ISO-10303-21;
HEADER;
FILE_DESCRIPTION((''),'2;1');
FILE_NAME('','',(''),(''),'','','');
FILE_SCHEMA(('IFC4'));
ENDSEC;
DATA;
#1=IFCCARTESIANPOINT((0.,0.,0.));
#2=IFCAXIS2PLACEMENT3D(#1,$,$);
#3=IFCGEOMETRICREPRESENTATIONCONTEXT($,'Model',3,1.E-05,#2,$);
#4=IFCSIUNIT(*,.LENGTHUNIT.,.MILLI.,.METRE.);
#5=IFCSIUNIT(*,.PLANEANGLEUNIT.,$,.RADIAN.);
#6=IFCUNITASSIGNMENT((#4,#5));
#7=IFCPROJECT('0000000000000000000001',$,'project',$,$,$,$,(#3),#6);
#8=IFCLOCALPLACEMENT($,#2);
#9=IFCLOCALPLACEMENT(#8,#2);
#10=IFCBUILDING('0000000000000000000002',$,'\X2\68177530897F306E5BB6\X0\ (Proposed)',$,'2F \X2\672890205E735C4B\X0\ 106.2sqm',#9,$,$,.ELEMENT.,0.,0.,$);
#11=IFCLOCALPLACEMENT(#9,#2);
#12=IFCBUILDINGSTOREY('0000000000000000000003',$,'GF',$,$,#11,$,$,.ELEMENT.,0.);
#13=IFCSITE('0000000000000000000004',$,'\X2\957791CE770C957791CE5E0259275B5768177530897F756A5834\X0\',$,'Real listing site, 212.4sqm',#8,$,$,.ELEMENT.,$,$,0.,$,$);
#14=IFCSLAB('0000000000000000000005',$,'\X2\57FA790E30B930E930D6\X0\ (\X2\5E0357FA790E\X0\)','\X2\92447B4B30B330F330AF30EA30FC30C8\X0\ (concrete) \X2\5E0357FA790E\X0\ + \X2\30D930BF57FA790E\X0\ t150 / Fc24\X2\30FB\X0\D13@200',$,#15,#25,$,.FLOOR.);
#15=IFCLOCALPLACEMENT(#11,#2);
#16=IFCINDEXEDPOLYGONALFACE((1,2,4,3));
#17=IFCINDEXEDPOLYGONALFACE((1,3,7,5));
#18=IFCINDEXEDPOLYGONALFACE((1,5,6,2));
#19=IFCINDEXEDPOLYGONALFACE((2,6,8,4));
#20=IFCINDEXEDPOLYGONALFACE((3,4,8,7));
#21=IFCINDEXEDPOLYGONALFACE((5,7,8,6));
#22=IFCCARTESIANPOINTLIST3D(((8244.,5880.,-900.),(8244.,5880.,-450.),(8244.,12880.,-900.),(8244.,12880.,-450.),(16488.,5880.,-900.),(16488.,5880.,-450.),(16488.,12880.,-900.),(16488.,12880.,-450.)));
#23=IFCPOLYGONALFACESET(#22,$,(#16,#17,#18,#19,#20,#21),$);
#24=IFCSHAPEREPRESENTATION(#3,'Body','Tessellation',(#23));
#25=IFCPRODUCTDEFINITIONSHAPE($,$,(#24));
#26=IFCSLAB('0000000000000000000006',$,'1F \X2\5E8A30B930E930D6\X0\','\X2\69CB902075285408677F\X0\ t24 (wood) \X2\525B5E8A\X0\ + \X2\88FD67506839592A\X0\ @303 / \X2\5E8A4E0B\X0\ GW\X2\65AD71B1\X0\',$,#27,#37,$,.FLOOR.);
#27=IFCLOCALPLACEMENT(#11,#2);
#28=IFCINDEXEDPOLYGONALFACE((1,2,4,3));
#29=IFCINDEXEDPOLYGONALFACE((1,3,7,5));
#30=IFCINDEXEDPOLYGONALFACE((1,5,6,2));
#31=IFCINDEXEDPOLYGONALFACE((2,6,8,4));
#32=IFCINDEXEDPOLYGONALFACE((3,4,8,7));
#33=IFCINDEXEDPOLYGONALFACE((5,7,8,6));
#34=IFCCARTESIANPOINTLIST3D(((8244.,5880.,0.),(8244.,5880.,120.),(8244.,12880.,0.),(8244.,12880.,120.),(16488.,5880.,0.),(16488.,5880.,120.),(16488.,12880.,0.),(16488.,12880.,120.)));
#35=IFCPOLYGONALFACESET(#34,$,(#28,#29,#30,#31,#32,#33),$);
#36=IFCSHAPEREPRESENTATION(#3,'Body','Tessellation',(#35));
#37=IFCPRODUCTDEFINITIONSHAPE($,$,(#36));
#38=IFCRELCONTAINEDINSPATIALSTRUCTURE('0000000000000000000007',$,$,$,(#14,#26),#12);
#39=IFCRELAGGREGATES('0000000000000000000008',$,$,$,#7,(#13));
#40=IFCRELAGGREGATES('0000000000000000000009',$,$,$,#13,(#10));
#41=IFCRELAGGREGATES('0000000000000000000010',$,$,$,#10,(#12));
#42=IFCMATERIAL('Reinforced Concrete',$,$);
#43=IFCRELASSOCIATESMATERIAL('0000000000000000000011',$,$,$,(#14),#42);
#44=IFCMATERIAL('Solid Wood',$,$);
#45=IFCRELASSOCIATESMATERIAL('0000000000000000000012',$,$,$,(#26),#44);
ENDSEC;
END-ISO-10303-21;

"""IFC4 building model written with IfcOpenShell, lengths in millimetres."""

from ifc_helpers import new_model, si_unit, frame, frame_2d, origin, place, context, project, spatial, rectangle, extrude, material, element, save


model = new_model("IFC4")

# Units and contexts
model_context = context("Model", 3, precision=1e-05, world=origin())
ifc_project = project(units=[si_unit("LENGTHUNIT", "METRE", prefix="MILLI"), si_unit("PLANEANGLEUNIT", "RADIAN")], contexts=[model_context])

# Site, building, storey
site_placement = place(None, origin())
site = spatial("IfcSite", under=ifc_project, at=site_placement, Name="長野県長野市大字栗田西番場", ObjectType="Real listing site, 212.4sqm", CompositionType="ELEMENT", RefElevation=0.0)
building_placement = place(site_placement, origin())
building = spatial("IfcBuilding", under=site, at=building_placement, Name="栗田西の家 (Proposed)", ObjectType="2F 木造平屋 106.2sqm", CompositionType="ELEMENT", ElevationOfRefHeight=0.0, ElevationOfTerrain=0.0)
storey_placement = place(building_placement, origin())
storey = spatial("IfcBuildingStorey", under=building, at=storey_placement, Name="GF", CompositionType="ELEMENT", Elevation=0.0)

# Slabs
ifc_material_1 = material(Name="Reinforced Concrete")
slab_1_placement = place(storey_placement, frame((4122.0, 2940.0, -450.0)))
element("IfcSlab", 1, at=slab_1_placement, inside=storey, material=ifc_material_1, Name="基礎スラブ (布基礎)", Description="鉄筋コンクリート (concrete) 布基礎 + ベタ基礎 t150 / Fc24・D13@200", PredefinedType="FLOOR", context=model_context, shape_type="SweptSolid", body=[
    extrude(rectangle(XDim=8244.0, YDim=7000.0, at=frame_2d((4122.0, 3500.0))), frame((4122.0, 2940.0, -450.0)), (0.0, 0.0, 1.0), 450.0),
])
ifc_material_2 = material(Name="Solid Wood")
slab_2_placement = place(storey_placement, frame((4122.0, 2940.0, 0.0)))
element("IfcSlab", 2, at=slab_2_placement, inside=storey, material=ifc_material_2, Name="1F 床スラブ", Description="構造用合板 t24 (wood) 剛床 + 製材根太 @303 / 床下 GW断熱", PredefinedType="FLOOR", context=model_context, shape_type="SweptSolid", body=[
    extrude(rectangle(XDim=8244.0, YDim=7000.0, at=frame_2d((4122.0, 3500.0))), frame((4122.0, 2940.0, 0.0)), (0.0, 0.0, 1.0), 120.0),
])

save(model, "model.ifc")
